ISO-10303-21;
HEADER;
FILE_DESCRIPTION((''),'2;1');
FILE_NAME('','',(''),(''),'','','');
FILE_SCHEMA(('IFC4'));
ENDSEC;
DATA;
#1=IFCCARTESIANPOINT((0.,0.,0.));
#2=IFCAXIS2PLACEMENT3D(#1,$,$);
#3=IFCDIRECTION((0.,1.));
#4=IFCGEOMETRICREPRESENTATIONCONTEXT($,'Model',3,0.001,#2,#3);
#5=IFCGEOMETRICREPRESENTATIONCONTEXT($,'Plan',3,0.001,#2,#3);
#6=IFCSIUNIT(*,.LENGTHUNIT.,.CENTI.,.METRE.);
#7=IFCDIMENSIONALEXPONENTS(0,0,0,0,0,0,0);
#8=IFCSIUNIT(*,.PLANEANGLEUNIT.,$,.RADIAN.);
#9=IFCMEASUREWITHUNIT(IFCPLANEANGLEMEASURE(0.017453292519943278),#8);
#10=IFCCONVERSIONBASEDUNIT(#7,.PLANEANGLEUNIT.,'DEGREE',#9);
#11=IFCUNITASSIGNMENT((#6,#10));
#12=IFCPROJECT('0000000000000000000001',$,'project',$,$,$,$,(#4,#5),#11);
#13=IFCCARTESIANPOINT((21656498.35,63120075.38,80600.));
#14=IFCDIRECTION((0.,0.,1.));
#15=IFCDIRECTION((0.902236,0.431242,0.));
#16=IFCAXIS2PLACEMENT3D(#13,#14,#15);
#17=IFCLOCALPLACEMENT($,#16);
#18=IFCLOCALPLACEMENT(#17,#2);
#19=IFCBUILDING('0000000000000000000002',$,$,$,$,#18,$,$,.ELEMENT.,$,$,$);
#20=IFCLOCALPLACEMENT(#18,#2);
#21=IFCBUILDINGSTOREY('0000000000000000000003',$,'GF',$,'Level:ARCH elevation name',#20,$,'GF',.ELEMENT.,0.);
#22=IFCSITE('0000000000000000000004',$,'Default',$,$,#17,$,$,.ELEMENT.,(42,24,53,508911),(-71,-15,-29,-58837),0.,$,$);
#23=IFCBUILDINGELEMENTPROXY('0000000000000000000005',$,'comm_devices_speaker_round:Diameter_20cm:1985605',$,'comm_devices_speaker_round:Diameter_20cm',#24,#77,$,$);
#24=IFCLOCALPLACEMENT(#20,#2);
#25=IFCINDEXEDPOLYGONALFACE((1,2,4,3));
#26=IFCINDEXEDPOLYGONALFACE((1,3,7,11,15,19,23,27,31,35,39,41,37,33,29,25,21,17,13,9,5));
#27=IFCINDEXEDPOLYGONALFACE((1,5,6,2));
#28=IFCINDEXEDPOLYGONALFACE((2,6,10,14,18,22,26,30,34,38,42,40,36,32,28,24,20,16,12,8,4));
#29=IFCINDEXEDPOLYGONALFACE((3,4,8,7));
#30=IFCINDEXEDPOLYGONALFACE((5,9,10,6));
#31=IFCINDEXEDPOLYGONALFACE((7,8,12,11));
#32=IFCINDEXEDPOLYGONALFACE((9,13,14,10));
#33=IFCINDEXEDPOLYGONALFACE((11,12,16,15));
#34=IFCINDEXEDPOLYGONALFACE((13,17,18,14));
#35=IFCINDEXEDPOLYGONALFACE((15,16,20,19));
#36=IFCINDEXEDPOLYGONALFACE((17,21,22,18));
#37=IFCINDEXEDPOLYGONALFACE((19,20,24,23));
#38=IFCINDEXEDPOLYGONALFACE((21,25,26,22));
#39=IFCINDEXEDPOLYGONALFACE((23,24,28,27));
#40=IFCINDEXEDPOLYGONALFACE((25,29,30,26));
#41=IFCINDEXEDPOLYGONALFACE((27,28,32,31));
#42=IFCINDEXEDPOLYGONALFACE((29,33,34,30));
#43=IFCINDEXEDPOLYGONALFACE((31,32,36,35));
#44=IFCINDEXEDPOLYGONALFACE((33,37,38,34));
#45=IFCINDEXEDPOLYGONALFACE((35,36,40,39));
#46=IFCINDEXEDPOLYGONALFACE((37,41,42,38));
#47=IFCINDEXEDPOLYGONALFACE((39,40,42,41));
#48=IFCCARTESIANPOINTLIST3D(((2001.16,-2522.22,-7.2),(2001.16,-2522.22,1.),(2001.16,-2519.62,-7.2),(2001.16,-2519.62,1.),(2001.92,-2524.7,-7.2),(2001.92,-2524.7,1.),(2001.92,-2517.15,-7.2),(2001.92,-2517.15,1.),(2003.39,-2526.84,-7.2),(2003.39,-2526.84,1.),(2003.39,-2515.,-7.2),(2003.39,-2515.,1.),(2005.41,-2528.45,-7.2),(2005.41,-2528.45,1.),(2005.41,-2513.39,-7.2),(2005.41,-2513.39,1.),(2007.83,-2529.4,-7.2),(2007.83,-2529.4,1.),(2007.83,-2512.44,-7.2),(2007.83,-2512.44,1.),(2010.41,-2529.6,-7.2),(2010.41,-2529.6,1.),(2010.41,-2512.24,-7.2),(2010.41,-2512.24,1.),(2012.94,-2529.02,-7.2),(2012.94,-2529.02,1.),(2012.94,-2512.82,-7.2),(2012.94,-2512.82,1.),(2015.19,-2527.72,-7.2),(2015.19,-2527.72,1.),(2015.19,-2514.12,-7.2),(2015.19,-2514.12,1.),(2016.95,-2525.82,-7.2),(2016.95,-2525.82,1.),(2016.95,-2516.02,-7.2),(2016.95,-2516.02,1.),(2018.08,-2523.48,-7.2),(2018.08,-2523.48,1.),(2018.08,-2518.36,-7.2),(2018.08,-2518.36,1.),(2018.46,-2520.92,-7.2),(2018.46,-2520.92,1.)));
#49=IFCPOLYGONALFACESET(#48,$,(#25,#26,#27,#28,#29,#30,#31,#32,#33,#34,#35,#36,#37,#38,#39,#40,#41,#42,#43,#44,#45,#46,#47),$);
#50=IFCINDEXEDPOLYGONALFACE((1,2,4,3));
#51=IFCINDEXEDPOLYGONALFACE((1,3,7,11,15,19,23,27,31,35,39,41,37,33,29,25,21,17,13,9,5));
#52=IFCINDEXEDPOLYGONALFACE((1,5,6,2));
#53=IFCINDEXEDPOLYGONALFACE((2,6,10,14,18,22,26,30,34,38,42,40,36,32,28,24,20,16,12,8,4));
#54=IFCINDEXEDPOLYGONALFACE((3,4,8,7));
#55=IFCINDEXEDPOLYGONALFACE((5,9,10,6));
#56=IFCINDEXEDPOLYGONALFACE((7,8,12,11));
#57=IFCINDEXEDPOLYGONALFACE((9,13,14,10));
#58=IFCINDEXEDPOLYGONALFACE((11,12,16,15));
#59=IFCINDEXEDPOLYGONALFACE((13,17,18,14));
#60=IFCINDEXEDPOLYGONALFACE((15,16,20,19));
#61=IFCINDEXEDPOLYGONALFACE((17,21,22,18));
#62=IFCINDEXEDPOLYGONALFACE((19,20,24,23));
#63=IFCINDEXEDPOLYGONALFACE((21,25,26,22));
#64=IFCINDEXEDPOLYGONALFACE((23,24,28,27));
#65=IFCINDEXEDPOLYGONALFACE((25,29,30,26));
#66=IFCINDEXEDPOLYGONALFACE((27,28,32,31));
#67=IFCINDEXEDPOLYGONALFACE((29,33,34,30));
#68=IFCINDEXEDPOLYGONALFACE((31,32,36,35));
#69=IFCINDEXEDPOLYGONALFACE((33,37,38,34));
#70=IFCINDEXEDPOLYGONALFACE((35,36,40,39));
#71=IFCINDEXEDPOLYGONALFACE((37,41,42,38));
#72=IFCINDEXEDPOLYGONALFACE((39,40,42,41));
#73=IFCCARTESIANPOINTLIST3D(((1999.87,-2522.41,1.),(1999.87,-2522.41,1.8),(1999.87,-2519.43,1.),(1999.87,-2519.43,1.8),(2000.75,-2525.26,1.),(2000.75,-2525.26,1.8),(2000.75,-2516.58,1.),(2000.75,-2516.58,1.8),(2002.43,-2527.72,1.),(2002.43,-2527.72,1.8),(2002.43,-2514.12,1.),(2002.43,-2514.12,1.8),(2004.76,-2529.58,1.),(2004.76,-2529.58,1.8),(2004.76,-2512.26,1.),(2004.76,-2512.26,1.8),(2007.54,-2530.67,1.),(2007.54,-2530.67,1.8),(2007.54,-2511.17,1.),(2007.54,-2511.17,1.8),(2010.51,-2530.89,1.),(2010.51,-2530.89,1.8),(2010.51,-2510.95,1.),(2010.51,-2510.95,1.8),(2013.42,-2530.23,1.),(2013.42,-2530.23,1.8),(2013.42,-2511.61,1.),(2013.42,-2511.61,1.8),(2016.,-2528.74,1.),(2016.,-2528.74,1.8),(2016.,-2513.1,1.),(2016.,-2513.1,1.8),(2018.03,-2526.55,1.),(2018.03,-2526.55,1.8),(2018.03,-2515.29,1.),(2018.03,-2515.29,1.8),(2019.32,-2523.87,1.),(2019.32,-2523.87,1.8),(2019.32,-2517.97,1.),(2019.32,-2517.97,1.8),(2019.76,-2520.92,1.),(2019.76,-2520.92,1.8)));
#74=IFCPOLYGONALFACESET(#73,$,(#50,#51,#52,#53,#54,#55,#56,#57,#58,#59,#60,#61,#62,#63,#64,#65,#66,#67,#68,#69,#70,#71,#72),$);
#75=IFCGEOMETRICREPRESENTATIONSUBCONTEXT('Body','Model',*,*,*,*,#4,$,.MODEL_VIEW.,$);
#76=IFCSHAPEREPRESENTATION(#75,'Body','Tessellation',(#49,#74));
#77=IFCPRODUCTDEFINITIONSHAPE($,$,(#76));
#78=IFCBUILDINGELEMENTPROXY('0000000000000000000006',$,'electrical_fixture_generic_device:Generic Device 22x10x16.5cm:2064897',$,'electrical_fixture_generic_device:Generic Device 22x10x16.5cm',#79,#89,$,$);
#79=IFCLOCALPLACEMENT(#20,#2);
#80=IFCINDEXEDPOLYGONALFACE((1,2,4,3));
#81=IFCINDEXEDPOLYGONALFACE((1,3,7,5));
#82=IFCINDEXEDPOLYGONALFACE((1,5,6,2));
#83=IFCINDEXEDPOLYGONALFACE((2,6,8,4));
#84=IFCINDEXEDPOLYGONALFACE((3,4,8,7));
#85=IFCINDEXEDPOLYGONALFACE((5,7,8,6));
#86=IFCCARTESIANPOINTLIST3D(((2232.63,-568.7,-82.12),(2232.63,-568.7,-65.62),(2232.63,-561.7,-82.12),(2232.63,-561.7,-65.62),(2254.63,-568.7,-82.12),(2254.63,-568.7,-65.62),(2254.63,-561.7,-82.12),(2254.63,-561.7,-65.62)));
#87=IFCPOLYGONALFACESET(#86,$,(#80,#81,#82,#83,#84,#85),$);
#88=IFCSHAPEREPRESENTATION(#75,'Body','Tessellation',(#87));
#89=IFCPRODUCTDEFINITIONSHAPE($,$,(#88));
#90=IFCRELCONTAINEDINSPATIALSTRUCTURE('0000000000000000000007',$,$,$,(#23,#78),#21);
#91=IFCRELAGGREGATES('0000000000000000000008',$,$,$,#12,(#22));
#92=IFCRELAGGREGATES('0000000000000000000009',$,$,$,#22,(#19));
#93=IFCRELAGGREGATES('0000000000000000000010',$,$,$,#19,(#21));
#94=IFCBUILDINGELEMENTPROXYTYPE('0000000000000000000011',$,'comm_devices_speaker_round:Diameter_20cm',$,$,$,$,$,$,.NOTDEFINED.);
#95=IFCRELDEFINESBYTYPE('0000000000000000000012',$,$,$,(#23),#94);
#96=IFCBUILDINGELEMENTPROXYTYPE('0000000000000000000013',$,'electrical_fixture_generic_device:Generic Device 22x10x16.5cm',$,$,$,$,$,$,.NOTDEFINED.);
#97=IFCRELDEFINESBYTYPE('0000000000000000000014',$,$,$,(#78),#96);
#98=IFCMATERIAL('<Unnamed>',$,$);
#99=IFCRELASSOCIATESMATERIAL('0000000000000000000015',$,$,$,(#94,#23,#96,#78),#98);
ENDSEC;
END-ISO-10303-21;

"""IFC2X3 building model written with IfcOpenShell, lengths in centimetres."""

from ifc_helpers import new_model, entity, si_unit, converted_unit, direction, frame, frame_2d, origin, origin_2d_with_axis, place, context, subcontext, project, spatial, rectangle, circle, extrude, source, transform, mapped, material, type_object, type_shapes, element, save


model = new_model("IFC2X3")

# Units and contexts
model_context = context("Model", 3, precision=0.001, world=origin(), true_north=direction((0.0, 1.0)))
plan_context = context("Plan", 3, precision=0.001, world=origin(), true_north=direction((0.0, 1.0)))
body_context = subcontext(model_context, "Body", "Model", "MODEL_VIEW")
ifc_project = project(units=[si_unit("LENGTHUNIT", "METRE", prefix="CENTI"), converted_unit("PLANEANGLEUNIT", "DEGREE", entity("IfcPlaneAngleMeasure", 0.017453292519943278), si_unit("PLANEANGLEUNIT", "RADIAN"), dimensions=[0, 0, 0, 0, 0, 0, 0])], contexts=[model_context, plan_context])

# Site, building, storey
site_placement = place(None, frame((21656498.35, 63120075.38, 80600.0), z_axis=(0.0, 0.0, 1.0), x_axis=(0.902236, 0.431242, 0.0)))
site = spatial("IfcSite", under=ifc_project, at=site_placement, Name="Default", CompositionType="ELEMENT", RefLatitude=(42, 24, 53, 508911), RefLongitude=(-71, -15, -29, -58837), RefElevation=0.0)
building_placement = place(site_placement, origin())
building = spatial("IfcBuilding", under=site, at=building_placement, CompositionType="ELEMENT")
storey_placement = place(building_placement, origin())
storey = spatial("IfcBuildingStorey", under=building, at=storey_placement, Name="GF", ObjectType="Level:ARCH elevation name", LongName="GF", CompositionType="ELEMENT", Elevation=0.0)

# Building element proxies
ifc_material_1 = material(Name="<Unnamed>")
building_element_proxy_type_1 = type_object("IfcBuildingElementProxyType", Name="comm_devices_speaker_round:Diameter_20cm", PredefinedType="NOTDEFINED", material=ifc_material_1)
shared_shape_1 = source(origin(), body_context, "Body", "SweptSolid", [
    extrude(circle(Radius=8.7, at=frame_2d((0.0, 0.0), x_axis=(1.0, 0.0))), frame((0.0, 0.0, -8.2)), (0.0, 0.0, 1.0), 8.2),
    extrude(circle(Radius=10.0, at=frame_2d((0.0, 0.0), x_axis=(1.0, 0.0))), origin(), (0.0, 0.0, 1.0), 0.8),
])
type_shapes(building_element_proxy_type_1, [shared_shape_1])
proxy_1_placement = place(storey_placement, frame((2009.76, -2520.92, 1.0)))
element("IfcBuildingElementProxy", 1, at=proxy_1_placement, inside=storey, type_object=building_element_proxy_type_1, material=ifc_material_1, Name="comm_devices_speaker_round:Diameter_20cm:1985605", ObjectType="comm_devices_speaker_round:Diameter_20cm", context=body_context, shape_type="MappedRepresentation", body=[
    mapped(shared_shape_1, transform((0.0, 0.0, 0.0), scale=1.0)),
])
building_element_proxy_type_2 = type_object("IfcBuildingElementProxyType", Name="electrical_fixture_generic_device:Generic Device 22x10x16.5cm", PredefinedType="NOTDEFINED", material=ifc_material_1)
shared_shape_2 = source(origin(), body_context, "Body", "SweptSolid", [
    extrude(rectangle(XDim=22.0, YDim=7.0, at=origin_2d_with_axis()), frame((0.0, 0.0, 0.0), z_axis=(0.0, 0.0, 1.0), x_axis=(-1.0, 0.0, 0.0)), (0.0, 0.0, 1.0), 16.5),
])
type_shapes(building_element_proxy_type_2, [shared_shape_2])
proxy_2_placement = place(storey_placement, frame((2243.63, -565.2, -82.12)))
element("IfcBuildingElementProxy", 2, at=proxy_2_placement, inside=storey, type_object=building_element_proxy_type_2, material=ifc_material_1, Name="electrical_fixture_generic_device:Generic Device 22x10x16.5cm:2064897", ObjectType="electrical_fixture_generic_device:Generic Device 22x10x16.5cm", context=body_context, shape_type="MappedRepresentation", body=[
    mapped(shared_shape_2, transform((0.0, 0.0, 0.0), scale=1.0)),
])

save(model, "model.ifc")
